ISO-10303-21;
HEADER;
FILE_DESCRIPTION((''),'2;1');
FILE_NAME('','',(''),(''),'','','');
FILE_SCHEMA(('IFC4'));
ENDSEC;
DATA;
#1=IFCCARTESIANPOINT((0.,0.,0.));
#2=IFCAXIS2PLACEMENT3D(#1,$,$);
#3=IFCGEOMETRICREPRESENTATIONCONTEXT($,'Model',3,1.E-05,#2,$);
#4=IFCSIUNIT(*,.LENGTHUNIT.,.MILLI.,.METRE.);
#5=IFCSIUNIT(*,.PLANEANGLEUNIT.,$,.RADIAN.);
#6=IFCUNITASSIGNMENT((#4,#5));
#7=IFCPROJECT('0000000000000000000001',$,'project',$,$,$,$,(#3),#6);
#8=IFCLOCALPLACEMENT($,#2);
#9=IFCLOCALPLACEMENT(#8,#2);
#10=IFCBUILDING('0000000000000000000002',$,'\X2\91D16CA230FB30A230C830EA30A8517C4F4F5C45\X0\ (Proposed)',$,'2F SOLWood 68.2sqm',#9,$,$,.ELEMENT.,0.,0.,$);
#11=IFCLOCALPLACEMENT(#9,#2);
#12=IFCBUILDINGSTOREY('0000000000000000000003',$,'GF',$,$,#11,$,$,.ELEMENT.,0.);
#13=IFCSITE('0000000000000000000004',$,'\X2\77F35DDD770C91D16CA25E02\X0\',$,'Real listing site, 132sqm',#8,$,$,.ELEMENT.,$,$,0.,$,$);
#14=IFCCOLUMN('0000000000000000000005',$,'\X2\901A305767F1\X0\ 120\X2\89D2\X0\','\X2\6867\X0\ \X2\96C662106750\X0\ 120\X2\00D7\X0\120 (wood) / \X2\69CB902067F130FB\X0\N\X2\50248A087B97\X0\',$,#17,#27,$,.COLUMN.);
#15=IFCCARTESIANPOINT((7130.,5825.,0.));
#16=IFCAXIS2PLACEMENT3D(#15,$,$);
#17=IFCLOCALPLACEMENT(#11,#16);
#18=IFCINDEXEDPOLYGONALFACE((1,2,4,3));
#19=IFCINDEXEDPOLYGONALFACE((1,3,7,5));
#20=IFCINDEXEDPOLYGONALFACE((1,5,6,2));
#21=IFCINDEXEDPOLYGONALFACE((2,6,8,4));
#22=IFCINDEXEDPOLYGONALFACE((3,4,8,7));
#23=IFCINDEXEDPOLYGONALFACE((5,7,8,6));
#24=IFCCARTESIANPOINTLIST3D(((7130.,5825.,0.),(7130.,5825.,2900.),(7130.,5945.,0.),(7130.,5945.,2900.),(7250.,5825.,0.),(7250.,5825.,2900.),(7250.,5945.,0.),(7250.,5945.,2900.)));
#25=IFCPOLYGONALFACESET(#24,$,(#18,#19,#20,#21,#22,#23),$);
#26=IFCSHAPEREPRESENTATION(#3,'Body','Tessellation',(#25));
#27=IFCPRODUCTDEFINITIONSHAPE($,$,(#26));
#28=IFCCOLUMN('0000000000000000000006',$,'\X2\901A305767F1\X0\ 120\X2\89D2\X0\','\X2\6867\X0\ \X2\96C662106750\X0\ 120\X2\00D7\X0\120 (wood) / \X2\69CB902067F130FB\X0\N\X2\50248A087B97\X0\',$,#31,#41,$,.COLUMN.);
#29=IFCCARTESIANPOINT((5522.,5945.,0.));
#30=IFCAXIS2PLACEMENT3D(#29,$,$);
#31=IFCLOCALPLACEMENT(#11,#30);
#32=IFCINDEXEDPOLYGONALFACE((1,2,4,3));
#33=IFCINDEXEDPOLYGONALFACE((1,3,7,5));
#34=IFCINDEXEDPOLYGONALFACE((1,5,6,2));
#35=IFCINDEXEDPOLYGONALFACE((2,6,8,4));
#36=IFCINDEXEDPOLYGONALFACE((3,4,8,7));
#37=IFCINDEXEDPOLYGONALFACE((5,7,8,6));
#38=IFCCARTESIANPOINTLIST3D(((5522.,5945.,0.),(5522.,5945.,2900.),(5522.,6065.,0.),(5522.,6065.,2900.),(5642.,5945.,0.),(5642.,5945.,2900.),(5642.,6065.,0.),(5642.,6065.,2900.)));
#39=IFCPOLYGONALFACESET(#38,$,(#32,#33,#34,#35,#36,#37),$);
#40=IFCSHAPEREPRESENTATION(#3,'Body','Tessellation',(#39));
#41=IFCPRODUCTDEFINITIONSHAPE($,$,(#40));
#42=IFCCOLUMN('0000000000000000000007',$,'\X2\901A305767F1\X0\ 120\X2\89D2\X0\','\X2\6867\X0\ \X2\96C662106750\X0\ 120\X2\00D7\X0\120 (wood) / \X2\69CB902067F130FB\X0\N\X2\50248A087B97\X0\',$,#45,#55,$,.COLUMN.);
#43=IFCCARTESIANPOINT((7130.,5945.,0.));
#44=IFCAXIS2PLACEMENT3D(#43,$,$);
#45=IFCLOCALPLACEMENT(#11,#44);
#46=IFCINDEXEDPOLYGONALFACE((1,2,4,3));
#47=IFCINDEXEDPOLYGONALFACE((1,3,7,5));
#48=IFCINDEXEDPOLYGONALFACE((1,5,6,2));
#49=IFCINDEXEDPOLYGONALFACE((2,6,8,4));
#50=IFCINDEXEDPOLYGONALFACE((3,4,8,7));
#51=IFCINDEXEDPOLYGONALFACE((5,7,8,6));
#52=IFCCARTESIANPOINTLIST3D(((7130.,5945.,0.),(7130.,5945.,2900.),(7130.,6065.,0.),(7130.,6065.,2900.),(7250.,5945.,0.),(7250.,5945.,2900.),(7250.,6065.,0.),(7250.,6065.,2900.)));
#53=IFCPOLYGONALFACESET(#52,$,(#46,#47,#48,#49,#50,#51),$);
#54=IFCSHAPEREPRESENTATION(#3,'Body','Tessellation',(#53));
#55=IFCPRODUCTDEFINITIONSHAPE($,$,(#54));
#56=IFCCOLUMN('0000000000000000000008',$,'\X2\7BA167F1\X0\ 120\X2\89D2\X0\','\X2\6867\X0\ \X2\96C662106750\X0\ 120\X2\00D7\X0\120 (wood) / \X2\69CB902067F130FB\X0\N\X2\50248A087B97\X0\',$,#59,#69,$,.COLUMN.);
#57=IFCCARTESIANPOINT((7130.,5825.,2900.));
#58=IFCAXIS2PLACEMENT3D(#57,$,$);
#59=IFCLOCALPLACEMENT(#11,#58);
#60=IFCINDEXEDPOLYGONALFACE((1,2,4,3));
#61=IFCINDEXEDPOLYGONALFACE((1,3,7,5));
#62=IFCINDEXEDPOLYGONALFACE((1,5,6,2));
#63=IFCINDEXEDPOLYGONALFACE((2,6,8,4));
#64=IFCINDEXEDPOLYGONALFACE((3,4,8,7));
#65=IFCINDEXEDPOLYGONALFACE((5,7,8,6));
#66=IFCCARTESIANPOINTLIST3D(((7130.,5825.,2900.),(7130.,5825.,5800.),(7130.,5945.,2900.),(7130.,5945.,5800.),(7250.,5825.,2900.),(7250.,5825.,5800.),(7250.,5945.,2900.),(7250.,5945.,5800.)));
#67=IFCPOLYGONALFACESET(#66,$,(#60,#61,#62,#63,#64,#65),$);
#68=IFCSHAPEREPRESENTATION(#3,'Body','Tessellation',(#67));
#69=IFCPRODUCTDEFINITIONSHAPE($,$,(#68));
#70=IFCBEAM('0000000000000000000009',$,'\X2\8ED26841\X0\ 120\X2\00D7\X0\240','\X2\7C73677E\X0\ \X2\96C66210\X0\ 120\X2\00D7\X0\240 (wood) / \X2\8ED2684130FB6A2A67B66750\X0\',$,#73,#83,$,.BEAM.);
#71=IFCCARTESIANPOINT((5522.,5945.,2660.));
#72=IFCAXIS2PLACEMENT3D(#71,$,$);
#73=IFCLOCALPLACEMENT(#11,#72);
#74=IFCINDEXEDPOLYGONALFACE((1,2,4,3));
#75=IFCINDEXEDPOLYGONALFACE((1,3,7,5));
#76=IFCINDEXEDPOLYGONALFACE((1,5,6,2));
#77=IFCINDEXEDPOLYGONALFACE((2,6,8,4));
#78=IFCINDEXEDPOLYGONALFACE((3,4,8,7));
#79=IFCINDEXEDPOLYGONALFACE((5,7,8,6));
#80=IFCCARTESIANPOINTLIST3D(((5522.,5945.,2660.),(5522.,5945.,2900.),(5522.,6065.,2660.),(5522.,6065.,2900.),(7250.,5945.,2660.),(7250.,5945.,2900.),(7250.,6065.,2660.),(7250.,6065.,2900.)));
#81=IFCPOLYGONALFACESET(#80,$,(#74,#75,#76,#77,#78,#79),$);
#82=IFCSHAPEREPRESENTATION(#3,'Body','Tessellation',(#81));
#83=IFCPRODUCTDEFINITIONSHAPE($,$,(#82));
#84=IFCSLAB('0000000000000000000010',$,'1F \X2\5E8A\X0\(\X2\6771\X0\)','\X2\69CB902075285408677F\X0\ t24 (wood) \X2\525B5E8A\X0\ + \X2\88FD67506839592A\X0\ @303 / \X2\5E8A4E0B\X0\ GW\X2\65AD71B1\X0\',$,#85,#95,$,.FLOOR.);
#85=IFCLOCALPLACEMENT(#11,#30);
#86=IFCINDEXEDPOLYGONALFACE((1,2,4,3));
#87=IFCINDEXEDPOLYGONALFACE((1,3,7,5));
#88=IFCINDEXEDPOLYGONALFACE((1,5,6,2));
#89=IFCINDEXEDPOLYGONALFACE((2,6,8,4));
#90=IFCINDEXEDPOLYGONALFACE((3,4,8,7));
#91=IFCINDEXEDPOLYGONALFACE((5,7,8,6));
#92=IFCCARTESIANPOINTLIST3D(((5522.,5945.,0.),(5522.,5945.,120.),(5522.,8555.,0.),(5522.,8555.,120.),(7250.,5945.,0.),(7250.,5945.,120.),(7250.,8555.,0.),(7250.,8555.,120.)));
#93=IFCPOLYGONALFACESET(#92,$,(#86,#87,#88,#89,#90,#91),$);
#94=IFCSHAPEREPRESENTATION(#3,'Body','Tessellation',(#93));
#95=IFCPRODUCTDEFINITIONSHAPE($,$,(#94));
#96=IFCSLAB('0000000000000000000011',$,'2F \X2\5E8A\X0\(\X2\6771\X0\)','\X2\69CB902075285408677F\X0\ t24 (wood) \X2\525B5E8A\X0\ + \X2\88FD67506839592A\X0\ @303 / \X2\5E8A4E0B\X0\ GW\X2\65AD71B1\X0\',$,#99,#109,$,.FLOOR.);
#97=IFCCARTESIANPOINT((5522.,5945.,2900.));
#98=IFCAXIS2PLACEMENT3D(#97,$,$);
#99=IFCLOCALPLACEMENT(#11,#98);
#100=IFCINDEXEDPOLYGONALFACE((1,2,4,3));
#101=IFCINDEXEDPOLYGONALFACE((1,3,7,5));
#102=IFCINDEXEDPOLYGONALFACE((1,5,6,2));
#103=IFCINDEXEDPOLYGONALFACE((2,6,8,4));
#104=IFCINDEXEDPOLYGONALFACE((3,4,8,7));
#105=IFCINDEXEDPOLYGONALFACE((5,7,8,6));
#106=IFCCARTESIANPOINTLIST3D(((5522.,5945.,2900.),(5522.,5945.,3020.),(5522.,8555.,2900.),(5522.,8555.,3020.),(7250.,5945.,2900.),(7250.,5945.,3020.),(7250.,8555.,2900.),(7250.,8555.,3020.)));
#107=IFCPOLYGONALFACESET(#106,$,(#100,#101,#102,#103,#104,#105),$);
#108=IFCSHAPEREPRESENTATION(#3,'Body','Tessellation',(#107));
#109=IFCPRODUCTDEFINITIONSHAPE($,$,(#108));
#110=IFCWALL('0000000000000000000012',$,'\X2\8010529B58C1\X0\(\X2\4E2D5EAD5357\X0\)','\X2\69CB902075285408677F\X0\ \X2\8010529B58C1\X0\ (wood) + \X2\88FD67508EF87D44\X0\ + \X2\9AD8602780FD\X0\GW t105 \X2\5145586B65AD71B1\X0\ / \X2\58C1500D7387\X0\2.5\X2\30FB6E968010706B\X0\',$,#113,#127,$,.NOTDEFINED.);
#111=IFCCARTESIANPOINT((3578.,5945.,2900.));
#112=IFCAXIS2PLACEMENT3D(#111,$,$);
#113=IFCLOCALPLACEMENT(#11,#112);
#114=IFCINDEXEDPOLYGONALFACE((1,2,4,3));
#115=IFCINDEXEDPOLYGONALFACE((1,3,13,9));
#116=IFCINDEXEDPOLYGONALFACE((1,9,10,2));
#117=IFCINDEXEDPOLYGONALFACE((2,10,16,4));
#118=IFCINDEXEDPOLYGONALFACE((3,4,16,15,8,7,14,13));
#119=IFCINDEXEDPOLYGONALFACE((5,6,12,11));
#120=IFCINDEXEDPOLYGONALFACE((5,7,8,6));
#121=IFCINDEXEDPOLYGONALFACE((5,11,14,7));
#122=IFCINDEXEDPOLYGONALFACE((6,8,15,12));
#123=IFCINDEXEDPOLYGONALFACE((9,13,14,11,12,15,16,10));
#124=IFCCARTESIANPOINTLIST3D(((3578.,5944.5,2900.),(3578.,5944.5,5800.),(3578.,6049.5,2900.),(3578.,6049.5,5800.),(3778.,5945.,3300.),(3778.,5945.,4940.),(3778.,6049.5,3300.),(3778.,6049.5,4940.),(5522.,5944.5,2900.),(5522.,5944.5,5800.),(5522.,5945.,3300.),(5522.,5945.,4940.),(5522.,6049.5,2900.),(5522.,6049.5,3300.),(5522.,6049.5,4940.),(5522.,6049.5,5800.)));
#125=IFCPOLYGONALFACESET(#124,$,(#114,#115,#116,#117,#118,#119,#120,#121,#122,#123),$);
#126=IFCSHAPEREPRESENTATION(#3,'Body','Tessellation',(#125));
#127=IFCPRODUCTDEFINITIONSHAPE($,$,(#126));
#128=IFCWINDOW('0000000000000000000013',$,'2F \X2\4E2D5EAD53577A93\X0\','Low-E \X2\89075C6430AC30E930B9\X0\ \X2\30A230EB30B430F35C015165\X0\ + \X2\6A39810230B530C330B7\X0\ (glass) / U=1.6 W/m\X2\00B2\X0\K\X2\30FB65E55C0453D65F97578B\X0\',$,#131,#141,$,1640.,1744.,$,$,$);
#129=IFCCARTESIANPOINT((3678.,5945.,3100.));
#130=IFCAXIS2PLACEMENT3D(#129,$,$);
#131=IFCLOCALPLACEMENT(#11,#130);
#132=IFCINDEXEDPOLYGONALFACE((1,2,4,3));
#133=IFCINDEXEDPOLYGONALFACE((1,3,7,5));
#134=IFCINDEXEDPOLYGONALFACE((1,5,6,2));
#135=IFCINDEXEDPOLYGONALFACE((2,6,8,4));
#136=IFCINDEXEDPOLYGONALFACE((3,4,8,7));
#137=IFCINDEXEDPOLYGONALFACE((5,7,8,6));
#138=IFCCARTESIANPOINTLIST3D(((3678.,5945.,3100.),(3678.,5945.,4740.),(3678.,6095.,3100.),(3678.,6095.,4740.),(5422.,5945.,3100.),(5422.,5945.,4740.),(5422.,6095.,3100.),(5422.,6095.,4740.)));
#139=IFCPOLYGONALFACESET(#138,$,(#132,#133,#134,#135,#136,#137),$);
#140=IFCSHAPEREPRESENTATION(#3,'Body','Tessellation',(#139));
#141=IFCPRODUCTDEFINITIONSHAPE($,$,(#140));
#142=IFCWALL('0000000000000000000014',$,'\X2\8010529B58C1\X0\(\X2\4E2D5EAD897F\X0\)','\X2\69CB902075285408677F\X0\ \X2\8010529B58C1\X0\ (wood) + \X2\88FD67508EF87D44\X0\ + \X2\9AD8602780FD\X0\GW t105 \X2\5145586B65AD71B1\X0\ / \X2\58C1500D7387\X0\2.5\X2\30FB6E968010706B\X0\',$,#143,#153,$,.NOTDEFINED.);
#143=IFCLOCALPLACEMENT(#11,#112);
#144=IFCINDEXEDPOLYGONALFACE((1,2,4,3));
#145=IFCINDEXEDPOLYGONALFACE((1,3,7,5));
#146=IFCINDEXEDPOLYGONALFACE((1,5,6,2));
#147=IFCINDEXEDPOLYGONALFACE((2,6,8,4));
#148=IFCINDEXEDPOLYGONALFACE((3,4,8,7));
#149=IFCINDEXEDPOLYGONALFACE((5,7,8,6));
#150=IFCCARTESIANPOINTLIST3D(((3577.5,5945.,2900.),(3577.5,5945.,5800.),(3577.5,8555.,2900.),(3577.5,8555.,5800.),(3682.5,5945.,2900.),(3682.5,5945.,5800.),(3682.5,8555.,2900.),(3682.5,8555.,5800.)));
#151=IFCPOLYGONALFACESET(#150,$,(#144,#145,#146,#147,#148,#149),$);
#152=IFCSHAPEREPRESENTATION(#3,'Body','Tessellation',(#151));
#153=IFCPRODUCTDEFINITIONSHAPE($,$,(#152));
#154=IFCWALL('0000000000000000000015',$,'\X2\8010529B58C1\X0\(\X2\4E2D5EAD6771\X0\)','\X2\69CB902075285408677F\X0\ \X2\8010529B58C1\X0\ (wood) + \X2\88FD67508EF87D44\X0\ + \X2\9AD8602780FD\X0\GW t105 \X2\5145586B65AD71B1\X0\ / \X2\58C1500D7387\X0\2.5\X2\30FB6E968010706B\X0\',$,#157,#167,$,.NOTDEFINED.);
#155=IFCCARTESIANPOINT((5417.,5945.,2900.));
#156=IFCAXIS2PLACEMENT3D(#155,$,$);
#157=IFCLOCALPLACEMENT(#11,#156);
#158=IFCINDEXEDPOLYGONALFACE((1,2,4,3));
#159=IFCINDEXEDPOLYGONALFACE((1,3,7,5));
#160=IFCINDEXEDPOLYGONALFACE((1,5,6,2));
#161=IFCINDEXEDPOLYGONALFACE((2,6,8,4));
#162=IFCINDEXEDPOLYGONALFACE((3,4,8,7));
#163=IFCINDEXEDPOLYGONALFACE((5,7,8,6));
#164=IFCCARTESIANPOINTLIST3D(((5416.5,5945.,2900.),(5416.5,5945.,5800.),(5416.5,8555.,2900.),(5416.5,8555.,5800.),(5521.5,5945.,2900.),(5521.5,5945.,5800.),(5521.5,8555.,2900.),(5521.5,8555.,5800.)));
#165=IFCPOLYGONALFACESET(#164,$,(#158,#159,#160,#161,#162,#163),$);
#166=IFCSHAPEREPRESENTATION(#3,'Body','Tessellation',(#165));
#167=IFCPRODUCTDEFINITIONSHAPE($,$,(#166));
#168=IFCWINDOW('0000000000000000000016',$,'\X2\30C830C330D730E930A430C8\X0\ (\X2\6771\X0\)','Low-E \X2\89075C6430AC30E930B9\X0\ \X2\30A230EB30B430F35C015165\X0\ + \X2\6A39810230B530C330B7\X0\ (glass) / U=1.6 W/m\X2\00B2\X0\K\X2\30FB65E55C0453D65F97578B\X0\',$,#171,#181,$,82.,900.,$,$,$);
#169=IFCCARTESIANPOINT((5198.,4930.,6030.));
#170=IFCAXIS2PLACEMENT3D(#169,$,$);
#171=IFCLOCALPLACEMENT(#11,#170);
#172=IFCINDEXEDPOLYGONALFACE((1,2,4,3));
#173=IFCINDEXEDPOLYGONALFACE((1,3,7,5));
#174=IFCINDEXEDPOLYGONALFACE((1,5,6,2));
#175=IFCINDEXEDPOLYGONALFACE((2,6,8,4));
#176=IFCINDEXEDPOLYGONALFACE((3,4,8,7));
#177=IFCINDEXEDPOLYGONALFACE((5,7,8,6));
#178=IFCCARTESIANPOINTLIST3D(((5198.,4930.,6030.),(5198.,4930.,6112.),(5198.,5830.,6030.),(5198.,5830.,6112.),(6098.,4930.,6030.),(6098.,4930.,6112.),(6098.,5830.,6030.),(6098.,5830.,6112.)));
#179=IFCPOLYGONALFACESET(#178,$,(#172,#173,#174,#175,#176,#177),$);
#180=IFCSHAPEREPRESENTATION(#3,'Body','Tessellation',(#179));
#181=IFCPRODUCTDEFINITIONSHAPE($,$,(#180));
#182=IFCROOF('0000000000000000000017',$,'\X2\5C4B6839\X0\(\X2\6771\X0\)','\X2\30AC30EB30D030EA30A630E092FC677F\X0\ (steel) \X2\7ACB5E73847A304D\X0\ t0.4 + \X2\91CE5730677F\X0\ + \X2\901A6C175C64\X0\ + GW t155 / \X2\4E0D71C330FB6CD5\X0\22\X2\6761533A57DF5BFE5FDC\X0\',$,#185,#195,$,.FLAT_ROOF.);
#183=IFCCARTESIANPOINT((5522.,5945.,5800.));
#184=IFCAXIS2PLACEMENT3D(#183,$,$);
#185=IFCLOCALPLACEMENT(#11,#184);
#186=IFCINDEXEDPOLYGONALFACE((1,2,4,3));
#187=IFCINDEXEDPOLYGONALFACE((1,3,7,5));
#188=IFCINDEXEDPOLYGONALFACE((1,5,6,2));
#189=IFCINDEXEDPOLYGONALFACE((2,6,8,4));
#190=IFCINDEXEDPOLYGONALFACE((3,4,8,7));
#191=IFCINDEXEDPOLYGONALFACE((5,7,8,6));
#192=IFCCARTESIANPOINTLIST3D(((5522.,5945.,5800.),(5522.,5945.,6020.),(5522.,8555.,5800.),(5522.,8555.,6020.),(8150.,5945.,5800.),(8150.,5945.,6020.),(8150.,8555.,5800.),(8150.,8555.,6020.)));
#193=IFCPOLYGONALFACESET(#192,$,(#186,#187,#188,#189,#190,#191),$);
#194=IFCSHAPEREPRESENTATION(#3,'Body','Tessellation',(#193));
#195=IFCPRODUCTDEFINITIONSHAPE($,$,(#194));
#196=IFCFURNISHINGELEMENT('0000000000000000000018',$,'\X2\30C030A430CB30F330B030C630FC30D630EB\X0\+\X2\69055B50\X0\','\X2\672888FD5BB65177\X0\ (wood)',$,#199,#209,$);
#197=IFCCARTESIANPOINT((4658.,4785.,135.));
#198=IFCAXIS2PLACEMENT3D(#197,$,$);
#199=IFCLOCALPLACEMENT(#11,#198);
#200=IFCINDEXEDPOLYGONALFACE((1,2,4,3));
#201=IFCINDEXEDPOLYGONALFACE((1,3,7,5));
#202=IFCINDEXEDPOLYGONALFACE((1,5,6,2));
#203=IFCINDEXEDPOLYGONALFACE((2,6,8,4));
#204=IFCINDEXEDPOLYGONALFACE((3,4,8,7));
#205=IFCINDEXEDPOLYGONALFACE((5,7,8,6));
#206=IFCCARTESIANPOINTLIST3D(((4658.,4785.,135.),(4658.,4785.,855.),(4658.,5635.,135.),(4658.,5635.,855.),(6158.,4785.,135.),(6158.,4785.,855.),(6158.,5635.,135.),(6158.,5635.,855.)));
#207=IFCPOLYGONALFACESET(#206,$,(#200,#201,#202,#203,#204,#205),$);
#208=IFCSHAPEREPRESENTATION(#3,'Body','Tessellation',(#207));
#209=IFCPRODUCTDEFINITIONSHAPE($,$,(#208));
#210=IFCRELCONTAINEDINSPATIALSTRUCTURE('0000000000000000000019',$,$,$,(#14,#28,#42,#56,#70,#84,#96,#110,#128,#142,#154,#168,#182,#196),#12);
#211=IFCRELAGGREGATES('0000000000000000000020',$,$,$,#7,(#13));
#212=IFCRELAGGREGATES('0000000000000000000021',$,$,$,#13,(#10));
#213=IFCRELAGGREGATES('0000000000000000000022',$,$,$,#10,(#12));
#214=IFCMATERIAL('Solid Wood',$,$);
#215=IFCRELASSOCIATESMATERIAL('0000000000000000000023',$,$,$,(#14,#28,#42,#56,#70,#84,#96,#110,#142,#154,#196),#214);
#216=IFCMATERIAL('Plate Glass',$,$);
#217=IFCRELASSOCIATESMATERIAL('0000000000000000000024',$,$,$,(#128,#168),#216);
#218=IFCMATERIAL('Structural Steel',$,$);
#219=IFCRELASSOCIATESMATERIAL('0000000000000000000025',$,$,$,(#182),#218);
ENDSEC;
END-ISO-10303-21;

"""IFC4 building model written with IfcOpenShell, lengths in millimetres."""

from ifc_helpers import new_model, si_unit, frame, frame_2d, origin, place, context, project, spatial, rectangle, extrude, material, element, fill, save


model = new_model("IFC4")

# Units and contexts
model_context = context("Model", 3, precision=1e-05, world=origin())
ifc_project = project(units=[si_unit("LENGTHUNIT", "METRE", prefix="MILLI"), si_unit("PLANEANGLEUNIT", "RADIAN")], contexts=[model_context])

# Site, building, storey
site_placement = place(None, origin())
site = spatial("IfcSite", under=ifc_project, at=site_placement, Name="石川県金沢市", ObjectType="Real listing site, 132sqm", CompositionType="ELEMENT", RefElevation=0.0)
building_placement = place(site_placement, origin())
building = spatial("IfcBuilding", under=site, at=building_placement, Name="金沢・アトリエ兼住居 (Proposed)", ObjectType="2F SOLWood 68.2sqm", CompositionType="ELEMENT", ElevationOfRefHeight=0.0, ElevationOfTerrain=0.0)
storey_placement = place(building_placement, origin())
storey = spatial("IfcBuildingStorey", under=building, at=storey_placement, Name="GF", CompositionType="ELEMENT", Elevation=0.0)

# Columns
ifc_material_1 = material(Name="Solid Wood")
column_1_placement = place(storey_placement, frame((7130.0, 5825.0, 0.0)))
element("IfcColumn", 1, at=column_1_placement, inside=storey, material=ifc_material_1, Name="通し柱 120角", Description="桧 集成材 120×120 (wood) / 構造柱・N値計算", PredefinedType="COLUMN", context=model_context, shape_type="SweptSolid", body=[
    extrude(rectangle(XDim=120.0, YDim=120.0, at=frame_2d((60.0, 60.0))), frame((7130.0, 5825.0, 0.0)), (0.0, 0.0, 1.0), 2900.0),
])
column_2_placement = place(storey_placement, frame((5522.0, 5945.0, 0.0)))
element("IfcColumn", 2, at=column_2_placement, inside=storey, material=ifc_material_1, Name="通し柱 120角", Description="桧 集成材 120×120 (wood) / 構造柱・N値計算", PredefinedType="COLUMN", context=model_context, shape_type="SweptSolid", body=[
    extrude(rectangle(XDim=120.0, YDim=120.0, at=frame_2d((60.0, 60.0))), frame((5522.0, 5945.0, 0.0)), (0.0, 0.0, 1.0), 2900.0),
])
column_3_placement = place(storey_placement, frame((7130.0, 5945.0, 0.0)))
element("IfcColumn", 3, at=column_3_placement, inside=storey, material=ifc_material_1, Name="通し柱 120角", Description="桧 集成材 120×120 (wood) / 構造柱・N値計算", PredefinedType="COLUMN", context=model_context, shape_type="SweptSolid", body=[
    extrude(rectangle(XDim=120.0, YDim=120.0, at=frame_2d((60.0, 60.0))), frame((7130.0, 5945.0, 0.0)), (0.0, 0.0, 1.0), 2900.0),
])
column_4_placement = place(storey_placement, frame((7130.0, 5825.0, 2900.0)))
element("IfcColumn", 4, at=column_4_placement, inside=storey, material=ifc_material_1, Name="管柱 120角", Description="桧 集成材 120×120 (wood) / 構造柱・N値計算", PredefinedType="COLUMN", context=model_context, shape_type="SweptSolid", body=[
    extrude(rectangle(XDim=120.0, YDim=120.0, at=frame_2d((60.0, 60.0))), frame((7130.0, 5825.0, 2900.0)), (0.0, 0.0, 1.0), 2900.0),
])

# Beam
beam_1_placement = place(storey_placement, frame((5522.0, 5945.0, 2660.0)))
element("IfcBeam", 5, at=beam_1_placement, inside=storey, material=ifc_material_1, Name="軒桁 120×240", Description="米松 集成 120×240 (wood) / 軒桁・横架材", PredefinedType="BEAM", context=model_context, shape_type="SweptSolid", body=[
    extrude(rectangle(XDim=1728.0, YDim=120.0, at=frame_2d((864.0, 60.0))), frame((5522.0, 5945.0, 2660.0)), (0.0, 0.0, 1.0), 240.0),
])

# Slabs
slab_1_placement = place(storey_placement, frame((5522.0, 5945.0, 0.0)))
element("IfcSlab", 6, at=slab_1_placement, inside=storey, material=ifc_material_1, Name="1F 床(東)", Description="構造用合板 t24 (wood) 剛床 + 製材根太 @303 / 床下 GW断熱", PredefinedType="FLOOR", context=model_context, shape_type="SweptSolid", body=[
    extrude(rectangle(XDim=1728.0, YDim=2610.0, at=frame_2d((864.0, 1305.0))), frame((5522.0, 5945.0, 0.0)), (0.0, 0.0, 1.0), 120.0),
])
slab_2_placement = place(storey_placement, frame((5522.0, 5945.0, 2900.0)))
element("IfcSlab", 7, at=slab_2_placement, inside=storey, material=ifc_material_1, Name="2F 床(東)", Description="構造用合板 t24 (wood) 剛床 + 製材根太 @303 / 床下 GW断熱", PredefinedType="FLOOR", context=model_context, shape_type="SweptSolid", body=[
    extrude(rectangle(XDim=1728.0, YDim=2610.0, at=frame_2d((864.0, 1305.0))), frame((5522.0, 5945.0, 2900.0)), (0.0, 0.0, 1.0), 120.0),
])

# Wall, opening, window
wall_1_placement = place(storey_placement, frame((3578.0, 5945.0, 2900.0)))
wall_1 = element("IfcWall", 8, at=wall_1_placement, inside=storey, material=ifc_material_1, Name="耐力壁(中庭南)", Description="構造用合板 耐力壁 (wood) + 製材軸組 + 高性能GW t105 充填断熱 / 壁倍率2.5・準耐火", PredefinedType="NOTDEFINED", context=model_context, shape_type="SweptSolid", body=[
    extrude(rectangle(XDim=1944.0, YDim=105.0, at=frame_2d((972.0, 52.0))), frame((3578.0, 5945.0, 2900.0)), (0.0, 0.0, 1.0), 2900.0),
])
opening_placement = place(storey_placement, frame((3678.0, 5945.0, 3100.0)))
opening = element("IfcOpeningElement", 9, at=opening_placement, cuts=wall_1, PredefinedType="NOTDEFINED", context=model_context, shape_type="SweptSolid", body=[
    extrude(rectangle(XDim=1744.0, YDim=150.0, at=frame_2d((872.0, 75.0))), frame((3678.0, 5945.0, 3100.0)), (0.0, 0.0, 1.0), 1640.0),
])
ifc_material_2 = material(Name="Plate Glass")
window_1_placement = place(storey_placement, frame((3678.0, 5945.0, 3100.0)))
window_1 = element("IfcWindow", 10, at=window_1_placement, inside=storey, material=ifc_material_2, Name="2F 中庭南窓", Description="Low-E 複層ガラス アルゴン封入 + 樹脂サッシ (glass) / U=1.6 W/m²K・日射取得型", OverallHeight=1640.0, OverallWidth=1744.0, context=model_context, shape_type="SweptSolid", body=[
    extrude(rectangle(XDim=1744.0, YDim=150.0, at=frame_2d((872.0, 75.0))), frame((3678.0, 5945.0, 3100.0)), (0.0, 0.0, 1.0), 1640.0),
])
fill(opening, window_1)

# Walls
wall_2_placement = place(storey_placement, frame((3578.0, 5945.0, 2900.0)))
element("IfcWall", 11, at=wall_2_placement, inside=storey, material=ifc_material_1, Name="耐力壁(中庭西)", Description="構造用合板 耐力壁 (wood) + 製材軸組 + 高性能GW t105 充填断熱 / 壁倍率2.5・準耐火", PredefinedType="NOTDEFINED", context=model_context, shape_type="SweptSolid", body=[
    extrude(rectangle(XDim=105.0, YDim=2610.0, at=frame_2d((52.0, 1305.0))), frame((3578.0, 5945.0, 2900.0)), (0.0, 0.0, 1.0), 2900.0),
])
wall_3_placement = place(storey_placement, frame((5417.0, 5945.0, 2900.0)))
element("IfcWall", 12, at=wall_3_placement, inside=storey, material=ifc_material_1, Name="耐力壁(中庭東)", Description="構造用合板 耐力壁 (wood) + 製材軸組 + 高性能GW t105 充填断熱 / 壁倍率2.5・準耐火", PredefinedType="NOTDEFINED", context=model_context, shape_type="SweptSolid", body=[
    extrude(rectangle(XDim=105.0, YDim=2610.0, at=frame_2d((52.0, 1305.0))), frame((5417.0, 5945.0, 2900.0)), (0.0, 0.0, 1.0), 2900.0),
])

# Window
window_2_placement = place(storey_placement, frame((5198.0, 4930.0, 6030.0)))
element("IfcWindow", 13, at=window_2_placement, inside=storey, material=ifc_material_2, Name="トップライト (東)", Description="Low-E 複層ガラス アルゴン封入 + 樹脂サッシ (glass) / U=1.6 W/m²K・日射取得型", OverallHeight=82.0, OverallWidth=900.0, context=model_context, shape_type="SweptSolid", body=[
    extrude(rectangle(XDim=900.0, YDim=900.0, at=frame_2d((450.0, 450.0))), frame((5198.0, 4930.0, 6030.0)), (0.0, 0.0, 1.0), 82.0),
])

# Roof
ifc_material_3 = material(Name="Structural Steel")
for number, where, name in (
    (14, (5522.0, 5945.0, 5800.0), "屋根(東)"),
):
    element("IfcRoof", number, at=place(storey_placement, frame(where)), inside=storey, material=ifc_material_3, Name=name, Description="ガルバリウム鋼板 (steel) 立平葺き t0.4 + 野地板 + 通気層 + GW t155 / 不燃・法22条区域対応", PredefinedType="FLAT_ROOF", context=model_context, shape_type="SweptSolid", body=[
        extrude(rectangle(XDim=2628.0, YDim=2610.0, at=frame_2d((1314.0, 1305.0))), frame((5522.0, 5945.0, 5800.0)), (0.0, 0.0, 1.0), 220.0),
    ])

# Furnishing element
furnishing_1_placement = place(storey_placement, frame((4658.0, 4785.0, 135.0)))
element("IfcFurnishingElement", 15, at=furnishing_1_placement, inside=storey, material=ifc_material_1, Name="ダイニングテーブル+椅子", Description="木製家具 (wood)", context=model_context, shape_type="SweptSolid", body=[
    extrude(rectangle(XDim=1500.0, YDim=850.0, at=frame_2d((750.0, 425.0))), frame((4658.0, 4785.0, 135.0)), (0.0, 0.0, 1.0), 720.0),
])

save(model, "model.ifc")
